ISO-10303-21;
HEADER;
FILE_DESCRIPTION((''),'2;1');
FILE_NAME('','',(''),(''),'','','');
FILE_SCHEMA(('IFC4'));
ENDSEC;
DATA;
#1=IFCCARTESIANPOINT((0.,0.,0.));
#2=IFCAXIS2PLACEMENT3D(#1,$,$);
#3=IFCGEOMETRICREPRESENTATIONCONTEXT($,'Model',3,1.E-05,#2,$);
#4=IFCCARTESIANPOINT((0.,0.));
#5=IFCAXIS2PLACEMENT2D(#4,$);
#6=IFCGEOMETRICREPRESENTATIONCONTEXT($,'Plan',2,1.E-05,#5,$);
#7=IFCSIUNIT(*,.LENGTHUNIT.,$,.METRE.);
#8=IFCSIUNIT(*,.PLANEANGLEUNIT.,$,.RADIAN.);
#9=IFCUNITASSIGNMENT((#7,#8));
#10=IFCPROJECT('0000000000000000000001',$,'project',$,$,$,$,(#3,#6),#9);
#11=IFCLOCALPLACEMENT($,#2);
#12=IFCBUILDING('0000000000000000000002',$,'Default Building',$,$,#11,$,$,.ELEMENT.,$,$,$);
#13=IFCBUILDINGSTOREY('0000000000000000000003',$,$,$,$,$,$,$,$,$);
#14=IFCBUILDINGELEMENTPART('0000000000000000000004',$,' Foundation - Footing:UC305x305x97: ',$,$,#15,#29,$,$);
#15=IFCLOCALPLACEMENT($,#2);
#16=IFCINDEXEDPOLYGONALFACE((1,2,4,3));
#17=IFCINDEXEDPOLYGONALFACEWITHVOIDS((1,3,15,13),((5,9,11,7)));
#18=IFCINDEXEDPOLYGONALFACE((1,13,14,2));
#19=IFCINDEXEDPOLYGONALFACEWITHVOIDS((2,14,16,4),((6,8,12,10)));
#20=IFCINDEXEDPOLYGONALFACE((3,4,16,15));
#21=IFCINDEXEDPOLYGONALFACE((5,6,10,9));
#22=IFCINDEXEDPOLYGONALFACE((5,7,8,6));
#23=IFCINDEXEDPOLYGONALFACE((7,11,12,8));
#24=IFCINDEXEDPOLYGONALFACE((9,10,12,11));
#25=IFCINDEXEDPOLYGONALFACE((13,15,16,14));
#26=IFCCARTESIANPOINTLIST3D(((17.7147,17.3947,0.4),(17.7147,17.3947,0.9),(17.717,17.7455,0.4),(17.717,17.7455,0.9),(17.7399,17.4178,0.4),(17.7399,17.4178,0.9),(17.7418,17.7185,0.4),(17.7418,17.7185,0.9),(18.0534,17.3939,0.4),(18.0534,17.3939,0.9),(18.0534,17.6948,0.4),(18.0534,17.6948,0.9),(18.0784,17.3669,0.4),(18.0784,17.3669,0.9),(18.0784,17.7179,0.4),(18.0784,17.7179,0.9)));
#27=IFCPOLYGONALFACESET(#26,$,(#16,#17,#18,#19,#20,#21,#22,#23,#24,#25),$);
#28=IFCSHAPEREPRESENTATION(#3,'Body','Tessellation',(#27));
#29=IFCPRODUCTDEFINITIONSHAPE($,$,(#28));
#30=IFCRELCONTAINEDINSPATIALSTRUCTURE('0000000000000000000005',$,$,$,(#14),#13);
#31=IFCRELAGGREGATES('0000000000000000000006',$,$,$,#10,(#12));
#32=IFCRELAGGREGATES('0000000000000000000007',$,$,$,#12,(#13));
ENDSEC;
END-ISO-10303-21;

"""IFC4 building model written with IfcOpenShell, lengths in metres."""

from ifc_helpers import new_model, si_unit, origin, origin_2d, place, context, project, spatial, polyline, outline, extrude, element, save


model = new_model("IFC4")

# Units and contexts
model_context = context("Model", 3, precision=1e-05, world=origin())
plan_context = context("Plan", 2, precision=1e-05, world=origin_2d())
ifc_project = project(units=[si_unit("LENGTHUNIT", "METRE"), si_unit("PLANEANGLEUNIT", "RADIAN")], contexts=[model_context, plan_context])

# Building, storey
building_placement = place(None, origin())
building = spatial("IfcBuilding", under=ifc_project, at=building_placement, Name="Default Building", CompositionType="ELEMENT")
storey = spatial("IfcBuildingStorey", under=building)

# Building element part, opening
building_element_part_1 = element("IfcBuildingElementPart", 1, inside=storey, Name=" Foundation - Footing:UC305x305x97: ", context=model_context, shape_type="SweptSolid", body=[
    extrude(outline(polyline([(17.7147, 17.3947, 0.4), (18.0784, 17.3669, 0.4), (18.0784, 17.7179, 0.4), (17.717, 17.7455, 0.4), (17.7147, 17.3947, 0.4)])), None, (0.0, 0.0, 1.0), 0.5),
])
element("IfcOpeningElement", 2, inside=storey, cuts=building_element_part_1, context=model_context, shape_type="SweptSolid", body=[
    extrude(outline(polyline([(17.7399, 17.4178, 0.4), (18.0534, 17.3939, 0.4), (18.0534, 17.6948, 0.4), (17.7418, 17.7185, 0.4), (17.7399, 17.4178, 0.4)])), None, (0.0, 0.0, 1.0), 0.5),
])

save(model, "model.ifc")
